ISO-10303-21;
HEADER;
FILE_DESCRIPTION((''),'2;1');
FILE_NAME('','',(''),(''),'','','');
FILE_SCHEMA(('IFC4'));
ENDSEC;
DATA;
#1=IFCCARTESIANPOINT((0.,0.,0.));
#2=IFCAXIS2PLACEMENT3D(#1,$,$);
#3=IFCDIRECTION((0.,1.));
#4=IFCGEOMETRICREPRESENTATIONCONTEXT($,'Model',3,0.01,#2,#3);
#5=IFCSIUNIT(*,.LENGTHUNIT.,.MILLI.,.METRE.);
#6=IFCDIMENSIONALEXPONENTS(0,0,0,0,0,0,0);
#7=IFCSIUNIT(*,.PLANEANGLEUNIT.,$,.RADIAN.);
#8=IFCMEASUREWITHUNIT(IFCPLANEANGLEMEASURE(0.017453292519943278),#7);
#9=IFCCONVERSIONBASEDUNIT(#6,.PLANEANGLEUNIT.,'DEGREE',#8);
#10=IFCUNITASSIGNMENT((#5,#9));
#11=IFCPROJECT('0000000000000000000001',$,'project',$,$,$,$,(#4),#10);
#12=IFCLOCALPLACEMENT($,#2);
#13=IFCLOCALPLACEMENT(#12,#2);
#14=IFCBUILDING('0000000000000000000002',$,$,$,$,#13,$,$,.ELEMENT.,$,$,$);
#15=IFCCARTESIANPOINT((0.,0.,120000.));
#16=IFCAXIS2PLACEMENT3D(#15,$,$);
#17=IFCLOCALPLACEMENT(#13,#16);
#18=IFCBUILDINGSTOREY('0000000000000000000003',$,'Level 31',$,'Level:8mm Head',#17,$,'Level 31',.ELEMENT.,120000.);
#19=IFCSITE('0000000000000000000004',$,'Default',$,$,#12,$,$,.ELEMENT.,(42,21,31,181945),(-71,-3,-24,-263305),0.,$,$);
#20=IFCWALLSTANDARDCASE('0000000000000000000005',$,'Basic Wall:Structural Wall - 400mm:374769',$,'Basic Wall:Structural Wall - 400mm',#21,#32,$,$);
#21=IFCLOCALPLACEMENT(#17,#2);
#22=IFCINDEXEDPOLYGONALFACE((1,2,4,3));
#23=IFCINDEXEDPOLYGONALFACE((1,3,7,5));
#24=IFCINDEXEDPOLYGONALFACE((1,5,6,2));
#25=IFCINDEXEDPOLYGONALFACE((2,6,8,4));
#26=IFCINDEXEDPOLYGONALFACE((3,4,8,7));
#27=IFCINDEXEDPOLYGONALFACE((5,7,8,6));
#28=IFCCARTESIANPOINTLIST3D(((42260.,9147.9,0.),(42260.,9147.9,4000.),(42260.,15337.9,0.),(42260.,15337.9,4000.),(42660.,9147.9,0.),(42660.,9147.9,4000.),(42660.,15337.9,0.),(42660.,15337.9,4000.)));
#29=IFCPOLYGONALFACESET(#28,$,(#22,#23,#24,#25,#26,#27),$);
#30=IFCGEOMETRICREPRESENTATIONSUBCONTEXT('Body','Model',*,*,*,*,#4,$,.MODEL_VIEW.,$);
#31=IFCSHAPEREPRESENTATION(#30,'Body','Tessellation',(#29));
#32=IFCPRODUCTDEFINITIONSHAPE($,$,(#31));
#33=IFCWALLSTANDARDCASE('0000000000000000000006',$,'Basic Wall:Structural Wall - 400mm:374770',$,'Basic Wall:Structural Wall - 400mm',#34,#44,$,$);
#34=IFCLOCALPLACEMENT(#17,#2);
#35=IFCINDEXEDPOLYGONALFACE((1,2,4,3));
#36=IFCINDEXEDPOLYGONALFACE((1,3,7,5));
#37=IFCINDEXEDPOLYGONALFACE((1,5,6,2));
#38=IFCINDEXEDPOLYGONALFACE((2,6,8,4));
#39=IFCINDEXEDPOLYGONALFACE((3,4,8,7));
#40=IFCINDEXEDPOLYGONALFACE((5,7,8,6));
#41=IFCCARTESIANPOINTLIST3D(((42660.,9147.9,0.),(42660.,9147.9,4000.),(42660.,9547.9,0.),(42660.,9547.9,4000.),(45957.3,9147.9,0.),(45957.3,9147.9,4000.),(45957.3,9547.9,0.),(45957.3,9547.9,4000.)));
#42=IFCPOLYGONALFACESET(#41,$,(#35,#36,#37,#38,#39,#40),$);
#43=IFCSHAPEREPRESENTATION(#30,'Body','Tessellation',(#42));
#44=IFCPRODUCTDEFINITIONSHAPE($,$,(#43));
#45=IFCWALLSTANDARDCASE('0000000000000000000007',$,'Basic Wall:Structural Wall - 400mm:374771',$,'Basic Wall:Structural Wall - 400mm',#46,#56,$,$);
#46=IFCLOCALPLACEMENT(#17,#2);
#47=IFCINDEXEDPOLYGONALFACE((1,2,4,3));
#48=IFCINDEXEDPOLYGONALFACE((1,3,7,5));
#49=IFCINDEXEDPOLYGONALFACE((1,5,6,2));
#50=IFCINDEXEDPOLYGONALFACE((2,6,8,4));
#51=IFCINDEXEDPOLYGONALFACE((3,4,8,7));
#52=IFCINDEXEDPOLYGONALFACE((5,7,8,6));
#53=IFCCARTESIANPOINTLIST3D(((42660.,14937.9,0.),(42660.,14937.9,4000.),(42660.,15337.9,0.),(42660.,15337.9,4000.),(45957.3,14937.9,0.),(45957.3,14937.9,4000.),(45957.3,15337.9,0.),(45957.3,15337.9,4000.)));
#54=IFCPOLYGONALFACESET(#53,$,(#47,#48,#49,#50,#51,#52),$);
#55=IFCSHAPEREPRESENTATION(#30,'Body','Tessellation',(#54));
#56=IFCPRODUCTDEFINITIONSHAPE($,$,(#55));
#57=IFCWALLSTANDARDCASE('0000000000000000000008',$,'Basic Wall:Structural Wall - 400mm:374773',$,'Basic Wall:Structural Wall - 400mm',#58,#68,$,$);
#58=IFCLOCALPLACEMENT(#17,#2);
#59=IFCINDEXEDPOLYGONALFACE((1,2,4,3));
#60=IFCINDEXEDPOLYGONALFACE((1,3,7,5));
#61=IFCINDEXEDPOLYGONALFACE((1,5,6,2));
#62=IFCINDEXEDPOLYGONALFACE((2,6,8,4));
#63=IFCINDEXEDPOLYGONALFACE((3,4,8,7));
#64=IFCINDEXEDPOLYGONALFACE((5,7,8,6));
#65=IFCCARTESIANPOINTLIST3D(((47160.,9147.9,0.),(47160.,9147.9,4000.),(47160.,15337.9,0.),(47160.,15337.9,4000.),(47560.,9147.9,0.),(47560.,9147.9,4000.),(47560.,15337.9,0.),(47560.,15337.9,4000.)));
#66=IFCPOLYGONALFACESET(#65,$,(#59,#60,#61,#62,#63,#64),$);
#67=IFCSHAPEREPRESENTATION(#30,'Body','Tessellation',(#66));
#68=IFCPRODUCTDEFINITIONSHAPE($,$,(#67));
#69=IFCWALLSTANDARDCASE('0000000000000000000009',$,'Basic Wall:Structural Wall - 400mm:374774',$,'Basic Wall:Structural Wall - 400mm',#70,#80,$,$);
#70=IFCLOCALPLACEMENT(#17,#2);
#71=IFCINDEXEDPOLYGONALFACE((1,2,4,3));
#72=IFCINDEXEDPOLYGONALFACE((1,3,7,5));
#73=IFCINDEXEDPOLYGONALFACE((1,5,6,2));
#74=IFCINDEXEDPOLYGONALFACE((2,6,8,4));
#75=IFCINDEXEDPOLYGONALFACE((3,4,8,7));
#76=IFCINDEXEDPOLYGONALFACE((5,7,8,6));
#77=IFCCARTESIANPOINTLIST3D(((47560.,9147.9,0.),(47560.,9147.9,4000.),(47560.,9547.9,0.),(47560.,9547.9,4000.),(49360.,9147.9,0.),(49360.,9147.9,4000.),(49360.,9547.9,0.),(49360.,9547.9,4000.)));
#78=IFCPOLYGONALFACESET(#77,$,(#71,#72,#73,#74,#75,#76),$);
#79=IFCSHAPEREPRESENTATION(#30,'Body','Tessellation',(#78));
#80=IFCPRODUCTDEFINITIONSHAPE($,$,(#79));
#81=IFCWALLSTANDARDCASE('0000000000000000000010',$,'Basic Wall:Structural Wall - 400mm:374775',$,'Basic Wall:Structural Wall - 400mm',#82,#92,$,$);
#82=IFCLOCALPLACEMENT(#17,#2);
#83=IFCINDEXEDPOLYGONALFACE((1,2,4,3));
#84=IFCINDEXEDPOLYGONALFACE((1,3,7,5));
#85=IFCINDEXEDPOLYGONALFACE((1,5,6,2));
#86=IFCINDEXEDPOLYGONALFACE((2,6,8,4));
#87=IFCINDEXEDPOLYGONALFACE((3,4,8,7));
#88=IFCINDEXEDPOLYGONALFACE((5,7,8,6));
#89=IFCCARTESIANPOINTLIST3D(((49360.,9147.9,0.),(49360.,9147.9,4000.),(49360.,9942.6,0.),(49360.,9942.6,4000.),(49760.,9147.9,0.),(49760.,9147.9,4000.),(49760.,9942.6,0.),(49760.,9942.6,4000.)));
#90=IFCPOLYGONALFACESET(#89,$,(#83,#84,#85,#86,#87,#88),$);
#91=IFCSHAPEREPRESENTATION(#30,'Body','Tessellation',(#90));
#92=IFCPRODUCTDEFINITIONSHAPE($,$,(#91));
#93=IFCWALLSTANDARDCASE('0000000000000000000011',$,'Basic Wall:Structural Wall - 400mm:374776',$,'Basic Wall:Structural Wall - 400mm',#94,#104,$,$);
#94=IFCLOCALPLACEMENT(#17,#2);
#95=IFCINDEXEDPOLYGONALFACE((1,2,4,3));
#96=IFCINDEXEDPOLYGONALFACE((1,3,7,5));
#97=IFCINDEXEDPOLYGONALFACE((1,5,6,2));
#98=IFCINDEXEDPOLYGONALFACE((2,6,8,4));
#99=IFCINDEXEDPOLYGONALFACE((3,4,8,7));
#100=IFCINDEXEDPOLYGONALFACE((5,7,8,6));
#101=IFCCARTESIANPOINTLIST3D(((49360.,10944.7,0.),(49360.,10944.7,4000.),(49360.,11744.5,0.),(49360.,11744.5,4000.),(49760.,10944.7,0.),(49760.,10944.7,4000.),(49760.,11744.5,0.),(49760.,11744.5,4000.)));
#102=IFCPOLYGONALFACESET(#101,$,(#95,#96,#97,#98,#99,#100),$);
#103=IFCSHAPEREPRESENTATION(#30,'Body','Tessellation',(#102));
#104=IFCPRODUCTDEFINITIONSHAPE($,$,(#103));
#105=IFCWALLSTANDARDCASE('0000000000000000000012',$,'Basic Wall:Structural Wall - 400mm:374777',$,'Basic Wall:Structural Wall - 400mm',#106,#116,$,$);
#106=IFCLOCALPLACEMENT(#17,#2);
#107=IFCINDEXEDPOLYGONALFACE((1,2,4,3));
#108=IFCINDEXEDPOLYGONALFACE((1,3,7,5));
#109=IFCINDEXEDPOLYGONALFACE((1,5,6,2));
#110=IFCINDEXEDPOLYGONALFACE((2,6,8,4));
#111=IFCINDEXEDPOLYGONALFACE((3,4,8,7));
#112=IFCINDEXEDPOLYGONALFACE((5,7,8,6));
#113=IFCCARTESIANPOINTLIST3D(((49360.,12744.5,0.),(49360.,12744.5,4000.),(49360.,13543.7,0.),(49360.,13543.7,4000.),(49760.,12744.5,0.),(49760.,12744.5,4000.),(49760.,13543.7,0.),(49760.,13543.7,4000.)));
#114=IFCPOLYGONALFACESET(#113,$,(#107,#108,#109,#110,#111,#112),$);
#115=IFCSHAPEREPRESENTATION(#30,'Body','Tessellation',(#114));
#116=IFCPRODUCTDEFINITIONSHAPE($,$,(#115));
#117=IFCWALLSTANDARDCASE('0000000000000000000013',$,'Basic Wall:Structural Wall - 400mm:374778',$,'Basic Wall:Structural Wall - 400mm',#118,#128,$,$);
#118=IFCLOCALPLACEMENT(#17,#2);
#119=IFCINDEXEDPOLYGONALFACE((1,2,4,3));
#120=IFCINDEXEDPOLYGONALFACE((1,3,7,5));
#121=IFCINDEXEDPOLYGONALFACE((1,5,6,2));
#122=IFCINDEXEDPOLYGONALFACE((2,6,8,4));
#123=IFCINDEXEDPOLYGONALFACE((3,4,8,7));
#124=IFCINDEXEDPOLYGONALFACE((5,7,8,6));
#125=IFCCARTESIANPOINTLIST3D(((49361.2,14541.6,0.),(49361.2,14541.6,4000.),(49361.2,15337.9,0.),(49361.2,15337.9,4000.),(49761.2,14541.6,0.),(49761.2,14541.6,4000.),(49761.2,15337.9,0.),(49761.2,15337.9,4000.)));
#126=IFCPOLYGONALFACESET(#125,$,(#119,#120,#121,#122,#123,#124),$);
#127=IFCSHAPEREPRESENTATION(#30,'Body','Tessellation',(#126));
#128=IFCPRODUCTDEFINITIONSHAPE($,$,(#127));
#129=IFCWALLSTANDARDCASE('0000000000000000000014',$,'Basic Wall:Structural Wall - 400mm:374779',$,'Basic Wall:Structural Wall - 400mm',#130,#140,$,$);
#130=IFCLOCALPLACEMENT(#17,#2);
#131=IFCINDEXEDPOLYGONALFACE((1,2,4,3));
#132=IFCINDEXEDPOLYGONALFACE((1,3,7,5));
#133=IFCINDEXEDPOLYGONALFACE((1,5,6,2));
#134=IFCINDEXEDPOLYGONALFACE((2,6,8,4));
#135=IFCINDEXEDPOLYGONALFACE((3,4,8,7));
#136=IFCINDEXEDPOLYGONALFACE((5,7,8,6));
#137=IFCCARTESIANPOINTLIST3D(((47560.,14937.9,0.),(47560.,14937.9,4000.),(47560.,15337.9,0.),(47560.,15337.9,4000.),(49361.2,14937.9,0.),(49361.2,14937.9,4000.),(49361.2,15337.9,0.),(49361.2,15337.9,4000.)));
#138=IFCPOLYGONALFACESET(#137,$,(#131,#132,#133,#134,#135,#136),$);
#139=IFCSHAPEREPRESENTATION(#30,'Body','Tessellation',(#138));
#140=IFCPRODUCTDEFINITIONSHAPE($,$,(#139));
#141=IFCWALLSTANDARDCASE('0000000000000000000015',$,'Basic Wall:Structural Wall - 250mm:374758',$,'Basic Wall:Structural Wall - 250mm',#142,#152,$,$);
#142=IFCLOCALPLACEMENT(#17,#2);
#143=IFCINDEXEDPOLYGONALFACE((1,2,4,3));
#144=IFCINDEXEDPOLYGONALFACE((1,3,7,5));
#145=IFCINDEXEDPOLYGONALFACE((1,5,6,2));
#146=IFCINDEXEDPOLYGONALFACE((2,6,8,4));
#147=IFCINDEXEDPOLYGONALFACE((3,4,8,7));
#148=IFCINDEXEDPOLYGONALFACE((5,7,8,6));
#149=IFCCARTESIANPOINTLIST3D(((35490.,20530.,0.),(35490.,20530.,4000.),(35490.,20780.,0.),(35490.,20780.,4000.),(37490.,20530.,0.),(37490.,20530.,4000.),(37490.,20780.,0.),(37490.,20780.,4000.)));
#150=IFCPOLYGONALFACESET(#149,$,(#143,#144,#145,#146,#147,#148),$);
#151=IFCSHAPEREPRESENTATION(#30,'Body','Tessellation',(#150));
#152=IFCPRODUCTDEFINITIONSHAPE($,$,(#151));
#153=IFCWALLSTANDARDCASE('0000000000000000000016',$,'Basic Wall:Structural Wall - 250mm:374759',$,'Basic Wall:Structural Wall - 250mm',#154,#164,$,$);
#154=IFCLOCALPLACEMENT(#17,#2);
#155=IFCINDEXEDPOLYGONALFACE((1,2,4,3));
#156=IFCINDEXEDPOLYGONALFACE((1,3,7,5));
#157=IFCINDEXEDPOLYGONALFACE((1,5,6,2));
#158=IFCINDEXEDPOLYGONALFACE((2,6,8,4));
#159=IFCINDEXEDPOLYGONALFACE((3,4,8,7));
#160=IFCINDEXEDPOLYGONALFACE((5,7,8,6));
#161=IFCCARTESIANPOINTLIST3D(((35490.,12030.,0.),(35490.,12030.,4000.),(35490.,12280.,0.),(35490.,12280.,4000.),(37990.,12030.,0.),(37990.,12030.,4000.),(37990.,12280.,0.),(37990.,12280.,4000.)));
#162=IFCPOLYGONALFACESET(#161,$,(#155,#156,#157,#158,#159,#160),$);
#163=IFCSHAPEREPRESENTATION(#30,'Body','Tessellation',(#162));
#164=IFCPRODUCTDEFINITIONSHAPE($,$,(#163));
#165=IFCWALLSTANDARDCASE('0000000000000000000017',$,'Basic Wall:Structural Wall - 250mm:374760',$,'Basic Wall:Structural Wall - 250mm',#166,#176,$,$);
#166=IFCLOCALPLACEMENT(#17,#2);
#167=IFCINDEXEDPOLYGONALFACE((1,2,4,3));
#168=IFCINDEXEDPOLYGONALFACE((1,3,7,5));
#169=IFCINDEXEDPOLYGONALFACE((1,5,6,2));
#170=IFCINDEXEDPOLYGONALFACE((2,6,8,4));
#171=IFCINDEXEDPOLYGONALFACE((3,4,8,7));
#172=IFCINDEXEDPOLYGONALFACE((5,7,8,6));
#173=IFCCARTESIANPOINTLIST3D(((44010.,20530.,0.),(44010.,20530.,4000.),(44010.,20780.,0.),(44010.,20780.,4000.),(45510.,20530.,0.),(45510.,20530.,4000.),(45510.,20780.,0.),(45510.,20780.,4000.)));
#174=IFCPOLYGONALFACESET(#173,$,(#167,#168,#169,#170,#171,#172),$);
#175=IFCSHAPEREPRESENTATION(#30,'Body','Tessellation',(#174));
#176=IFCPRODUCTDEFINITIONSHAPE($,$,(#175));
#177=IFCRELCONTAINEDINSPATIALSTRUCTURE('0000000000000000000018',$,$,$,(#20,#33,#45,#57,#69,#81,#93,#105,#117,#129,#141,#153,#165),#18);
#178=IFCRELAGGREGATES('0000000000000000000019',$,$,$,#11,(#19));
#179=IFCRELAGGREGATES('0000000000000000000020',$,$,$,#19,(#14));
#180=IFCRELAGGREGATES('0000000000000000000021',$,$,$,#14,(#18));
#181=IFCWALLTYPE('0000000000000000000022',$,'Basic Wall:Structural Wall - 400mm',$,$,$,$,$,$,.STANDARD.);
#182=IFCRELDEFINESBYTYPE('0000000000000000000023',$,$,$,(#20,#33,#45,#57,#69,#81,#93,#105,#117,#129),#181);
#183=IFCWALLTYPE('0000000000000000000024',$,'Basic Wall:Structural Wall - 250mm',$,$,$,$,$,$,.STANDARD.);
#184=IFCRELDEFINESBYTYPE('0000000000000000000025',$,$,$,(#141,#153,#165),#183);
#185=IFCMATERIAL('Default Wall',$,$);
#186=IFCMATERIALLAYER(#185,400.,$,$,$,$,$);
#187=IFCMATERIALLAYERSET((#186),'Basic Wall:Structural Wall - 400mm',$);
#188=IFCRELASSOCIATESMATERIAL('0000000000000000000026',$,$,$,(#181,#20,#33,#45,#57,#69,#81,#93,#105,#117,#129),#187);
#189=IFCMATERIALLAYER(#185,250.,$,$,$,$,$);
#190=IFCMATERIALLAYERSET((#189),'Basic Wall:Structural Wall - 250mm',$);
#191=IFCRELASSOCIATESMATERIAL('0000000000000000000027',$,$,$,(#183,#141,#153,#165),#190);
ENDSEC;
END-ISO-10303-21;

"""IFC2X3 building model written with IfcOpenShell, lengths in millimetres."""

from ifc_helpers import new_model, entity, si_unit, converted_unit, direction, frame, frame_2d, origin, place, context, subcontext, project, spatial, rectangle, extrude, material, layer, layer_set, layer_usage, type_object, element, save


model = new_model("IFC2X3")

# Units and contexts
model_context = context("Model", 3, precision=0.01, world=origin(), true_north=direction((0.0, 1.0)))
body_context = subcontext(model_context, "Body", "Model", "MODEL_VIEW")
ifc_project = project(units=[si_unit("LENGTHUNIT", "METRE", prefix="MILLI"), converted_unit("PLANEANGLEUNIT", "DEGREE", entity("IfcPlaneAngleMeasure", 0.017453292519943278), si_unit("PLANEANGLEUNIT", "RADIAN"), dimensions=[0, 0, 0, 0, 0, 0, 0])], contexts=[model_context])

# Site, building, storey
site_placement = place(None, origin())
site = spatial("IfcSite", under=ifc_project, at=site_placement, Name="Default", CompositionType="ELEMENT", RefLatitude=(42, 21, 31, 181945), RefLongitude=(-71, -3, -24, -263305), RefElevation=0.0)
building_placement = place(site_placement, origin())
building = spatial("IfcBuilding", under=site, at=building_placement, CompositionType="ELEMENT")
storey_placement = place(building_placement, frame((0.0, 0.0, 120000.0)))
storey = spatial("IfcBuildingStorey", under=building, at=storey_placement, Name="Level 31", ObjectType="Level:8mm Head", LongName="Level 31", CompositionType="ELEMENT", Elevation=120000.0)

# Walls
ifc_material_1 = material(Name="Default Wall")
ifc_layer_1 = layer(ifc_material_1, 400.0)
ifc_layer_set_1 = layer_set([ifc_layer_1], Name="Basic Wall:Structural Wall - 400mm")
ifc_layer_usage_1 = layer_usage(ifc_layer_set_1, "AXIS2", "POSITIVE", -200.0)
wall_type_1 = type_object("IfcWallType", Name="Basic Wall:Structural Wall - 400mm", PredefinedType="STANDARD", material=ifc_layer_set_1)
wall_1_placement = place(storey_placement, frame((42460.0, 15337.9, 0.0), z_axis=(0.0, 0.0, 1.0), x_axis=(0.0, -1.0, 0.0)))
element("IfcWallStandardCase", 1, at=wall_1_placement, inside=storey, type_object=wall_type_1, material=ifc_layer_usage_1, Name="Basic Wall:Structural Wall - 400mm:374769", ObjectType="Basic Wall:Structural Wall - 400mm", context=body_context, shape_type="SweptSolid", body=[
    extrude(rectangle(XDim=6190.0, YDim=400.0, at=frame_2d((3095.0, 0.0), x_axis=(-1.0, 0.0))), origin(), (0.0, 0.0, 1.0), 4000.0),
])
ifc_layer_usage_2 = layer_usage(ifc_layer_set_1, "AXIS2", "POSITIVE", -200.0)
wall_2_placement = place(storey_placement, frame((42660.0, 9347.9, 0.0)))
element("IfcWallStandardCase", 2, at=wall_2_placement, inside=storey, type_object=wall_type_1, material=ifc_layer_usage_2, Name="Basic Wall:Structural Wall - 400mm:374770", ObjectType="Basic Wall:Structural Wall - 400mm", context=body_context, shape_type="SweptSolid", body=[
    extrude(rectangle(XDim=3297.3, YDim=400.0, at=frame_2d((1648.6, 0.0), x_axis=(-1.0, 0.0))), origin(), (0.0, 0.0, 1.0), 4000.0),
])
ifc_layer_usage_3 = layer_usage(ifc_layer_set_1, "AXIS2", "POSITIVE", -200.0)
wall_3_placement = place(storey_placement, frame((45957.3, 15137.9, 0.0), z_axis=(0.0, 0.0, 1.0), x_axis=(-1.0, 0.0, 0.0)))
element("IfcWallStandardCase", 3, at=wall_3_placement, inside=storey, type_object=wall_type_1, material=ifc_layer_usage_3, Name="Basic Wall:Structural Wall - 400mm:374771", ObjectType="Basic Wall:Structural Wall - 400mm", context=body_context, shape_type="SweptSolid", body=[
    extrude(rectangle(XDim=3297.3, YDim=400.0, at=frame_2d((1648.6, 0.0), x_axis=(-1.0, 0.0))), origin(), (0.0, 0.0, 1.0), 4000.0),
])
ifc_layer_usage_4 = layer_usage(ifc_layer_set_1, "AXIS2", "POSITIVE", -200.0)
wall_4_placement = place(storey_placement, frame((47360.0, 15337.9, 0.0), z_axis=(0.0, 0.0, 1.0), x_axis=(0.0, -1.0, 0.0)))
element("IfcWallStandardCase", 4, at=wall_4_placement, inside=storey, type_object=wall_type_1, material=ifc_layer_usage_4, Name="Basic Wall:Structural Wall - 400mm:374773", ObjectType="Basic Wall:Structural Wall - 400mm", context=body_context, shape_type="SweptSolid", body=[
    extrude(rectangle(XDim=6190.0, YDim=400.0, at=frame_2d((3095.0, 0.0), x_axis=(-1.0, 0.0))), origin(), (0.0, 0.0, 1.0), 4000.0),
])
ifc_layer_usage_5 = layer_usage(ifc_layer_set_1, "AXIS2", "POSITIVE", -200.0)
wall_5_placement = place(storey_placement, frame((47560.0, 9347.9, 0.0)))
element("IfcWallStandardCase", 5, at=wall_5_placement, inside=storey, type_object=wall_type_1, material=ifc_layer_usage_5, Name="Basic Wall:Structural Wall - 400mm:374774", ObjectType="Basic Wall:Structural Wall - 400mm", context=body_context, shape_type="SweptSolid", body=[
    extrude(rectangle(XDim=1800.0, YDim=400.0, at=frame_2d((900.0, 0.0), x_axis=(-1.0, 0.0))), origin(), (0.0, 0.0, 1.0), 4000.0),
])
ifc_layer_usage_6 = layer_usage(ifc_layer_set_1, "AXIS2", "NEGATIVE", 200.0)
wall_6_placement = place(storey_placement, frame((49560.0, 9147.9, 0.0), z_axis=(0.0, 0.0, 1.0), x_axis=(0.0, 1.0, 0.0)))
element("IfcWallStandardCase", 6, at=wall_6_placement, inside=storey, type_object=wall_type_1, material=ifc_layer_usage_6, Name="Basic Wall:Structural Wall - 400mm:374775", ObjectType="Basic Wall:Structural Wall - 400mm", context=body_context, shape_type="SweptSolid", body=[
    extrude(rectangle(XDim=794.7, YDim=400.0, at=frame_2d((397.3, 0.0), x_axis=(-1.0, 0.0))), origin(), (0.0, 0.0, 1.0), 4000.0),
])
ifc_layer_usage_7 = layer_usage(ifc_layer_set_1, "AXIS2", "POSITIVE", -200.0)
wall_7_placement = place(storey_placement, frame((49560.0, 10944.7, 0.0), z_axis=(0.0, 0.0, 1.0), x_axis=(0.0, 1.0, 0.0)))
element("IfcWallStandardCase", 7, at=wall_7_placement, inside=storey, type_object=wall_type_1, material=ifc_layer_usage_7, Name="Basic Wall:Structural Wall - 400mm:374776", ObjectType="Basic Wall:Structural Wall - 400mm", context=body_context, shape_type="SweptSolid", body=[
    extrude(rectangle(XDim=799.8, YDim=400.0, at=frame_2d((399.9, 0.0), x_axis=(-1.0, 0.0))), origin(), (0.0, 0.0, 1.0), 4000.0),
])
ifc_layer_usage_8 = layer_usage(ifc_layer_set_1, "AXIS2", "POSITIVE", -200.0)
wall_8_placement = place(storey_placement, frame((49560.0, 12744.5, 0.0), z_axis=(0.0, 0.0, 1.0), x_axis=(0.0, 1.0, 0.0)))
element("IfcWallStandardCase", 8, at=wall_8_placement, inside=storey, type_object=wall_type_1, material=ifc_layer_usage_8, Name="Basic Wall:Structural Wall - 400mm:374777", ObjectType="Basic Wall:Structural Wall - 400mm", context=body_context, shape_type="SweptSolid", body=[
    extrude(rectangle(XDim=799.2, YDim=400.0, at=frame_2d((399.6, 0.0), x_axis=(-1.0, 0.0))), origin(), (0.0, 0.0, 1.0), 4000.0),
])
ifc_layer_usage_9 = layer_usage(ifc_layer_set_1, "AXIS2", "POSITIVE", -200.0)
wall_9_placement = place(storey_placement, frame((49561.2, 14541.6, 0.0), z_axis=(0.0, 0.0, 1.0), x_axis=(0.0, 1.0, 0.0)))
element("IfcWallStandardCase", 9, at=wall_9_placement, inside=storey, type_object=wall_type_1, material=ifc_layer_usage_9, Name="Basic Wall:Structural Wall - 400mm:374778", ObjectType="Basic Wall:Structural Wall - 400mm", context=body_context, shape_type="SweptSolid", body=[
    extrude(rectangle(XDim=796.3, YDim=400.0, at=frame_2d((398.2, 0.0), x_axis=(-1.0, 0.0))), origin(), (0.0, 0.0, 1.0), 4000.0),
])
ifc_layer_usage_10 = layer_usage(ifc_layer_set_1, "AXIS2", "POSITIVE", -200.0)
wall_10_placement = place(storey_placement, frame((49361.2, 15137.9, 0.0), z_axis=(0.0, 0.0, 1.0), x_axis=(-1.0, 0.0, 0.0)))
element("IfcWallStandardCase", 10, at=wall_10_placement, inside=storey, type_object=wall_type_1, material=ifc_layer_usage_10, Name="Basic Wall:Structural Wall - 400mm:374779", ObjectType="Basic Wall:Structural Wall - 400mm", context=body_context, shape_type="SweptSolid", body=[
    extrude(rectangle(XDim=1801.2, YDim=400.0, at=frame_2d((900.6, 0.0), x_axis=(-1.0, 0.0))), origin(), (0.0, 0.0, 1.0), 4000.0),
])
ifc_layer_2 = layer(ifc_material_1, 250.0)
ifc_layer_set_2 = layer_set([ifc_layer_2], Name="Basic Wall:Structural Wall - 250mm")
ifc_layer_usage_11 = layer_usage(ifc_layer_set_2, "AXIS2", "NEGATIVE", 125.0)
wall_type_2 = type_object("IfcWallType", Name="Basic Wall:Structural Wall - 250mm", PredefinedType="STANDARD", material=ifc_layer_set_2)
wall_11_placement = place(storey_placement, frame((35490.0, 20655.0, 0.0)))
element("IfcWallStandardCase", 11, at=wall_11_placement, inside=storey, type_object=wall_type_2, material=ifc_layer_usage_11, Name="Basic Wall:Structural Wall - 250mm:374758", ObjectType="Basic Wall:Structural Wall - 250mm", context=body_context, shape_type="SweptSolid", body=[
    extrude(rectangle(XDim=2000.0, YDim=250.0, at=frame_2d((1000.0, 0.0), x_axis=(-1.0, 0.0))), origin(), (0.0, 0.0, 1.0), 4000.0),
])
ifc_layer_usage_12 = layer_usage(ifc_layer_set_2, "AXIS2", "POSITIVE", -125.0)
wall_12_placement = place(storey_placement, frame((35490.0, 12155.0, 0.0)))
element("IfcWallStandardCase", 12, at=wall_12_placement, inside=storey, type_object=wall_type_2, material=ifc_layer_usage_12, Name="Basic Wall:Structural Wall - 250mm:374759", ObjectType="Basic Wall:Structural Wall - 250mm", context=body_context, shape_type="SweptSolid", body=[
    extrude(rectangle(XDim=2500.0, YDim=250.0, at=frame_2d((1250.0, 0.0), x_axis=(-1.0, 0.0))), origin(), (0.0, 0.0, 1.0), 4000.0),
])
ifc_layer_usage_13 = layer_usage(ifc_layer_set_2, "AXIS2", "NEGATIVE", 125.0)
wall_13_placement = place(storey_placement, frame((44010.0, 20655.0, 0.0)))
element("IfcWallStandardCase", 13, at=wall_13_placement, inside=storey, type_object=wall_type_2, material=ifc_layer_usage_13, Name="Basic Wall:Structural Wall - 250mm:374760", ObjectType="Basic Wall:Structural Wall - 250mm", context=body_context, shape_type="SweptSolid", body=[
    extrude(rectangle(XDim=1500.0, YDim=250.0, at=frame_2d((750.0, 0.0), x_axis=(-1.0, 0.0))), origin(), (0.0, 0.0, 1.0), 4000.0),
])

save(model, "model.ifc")
